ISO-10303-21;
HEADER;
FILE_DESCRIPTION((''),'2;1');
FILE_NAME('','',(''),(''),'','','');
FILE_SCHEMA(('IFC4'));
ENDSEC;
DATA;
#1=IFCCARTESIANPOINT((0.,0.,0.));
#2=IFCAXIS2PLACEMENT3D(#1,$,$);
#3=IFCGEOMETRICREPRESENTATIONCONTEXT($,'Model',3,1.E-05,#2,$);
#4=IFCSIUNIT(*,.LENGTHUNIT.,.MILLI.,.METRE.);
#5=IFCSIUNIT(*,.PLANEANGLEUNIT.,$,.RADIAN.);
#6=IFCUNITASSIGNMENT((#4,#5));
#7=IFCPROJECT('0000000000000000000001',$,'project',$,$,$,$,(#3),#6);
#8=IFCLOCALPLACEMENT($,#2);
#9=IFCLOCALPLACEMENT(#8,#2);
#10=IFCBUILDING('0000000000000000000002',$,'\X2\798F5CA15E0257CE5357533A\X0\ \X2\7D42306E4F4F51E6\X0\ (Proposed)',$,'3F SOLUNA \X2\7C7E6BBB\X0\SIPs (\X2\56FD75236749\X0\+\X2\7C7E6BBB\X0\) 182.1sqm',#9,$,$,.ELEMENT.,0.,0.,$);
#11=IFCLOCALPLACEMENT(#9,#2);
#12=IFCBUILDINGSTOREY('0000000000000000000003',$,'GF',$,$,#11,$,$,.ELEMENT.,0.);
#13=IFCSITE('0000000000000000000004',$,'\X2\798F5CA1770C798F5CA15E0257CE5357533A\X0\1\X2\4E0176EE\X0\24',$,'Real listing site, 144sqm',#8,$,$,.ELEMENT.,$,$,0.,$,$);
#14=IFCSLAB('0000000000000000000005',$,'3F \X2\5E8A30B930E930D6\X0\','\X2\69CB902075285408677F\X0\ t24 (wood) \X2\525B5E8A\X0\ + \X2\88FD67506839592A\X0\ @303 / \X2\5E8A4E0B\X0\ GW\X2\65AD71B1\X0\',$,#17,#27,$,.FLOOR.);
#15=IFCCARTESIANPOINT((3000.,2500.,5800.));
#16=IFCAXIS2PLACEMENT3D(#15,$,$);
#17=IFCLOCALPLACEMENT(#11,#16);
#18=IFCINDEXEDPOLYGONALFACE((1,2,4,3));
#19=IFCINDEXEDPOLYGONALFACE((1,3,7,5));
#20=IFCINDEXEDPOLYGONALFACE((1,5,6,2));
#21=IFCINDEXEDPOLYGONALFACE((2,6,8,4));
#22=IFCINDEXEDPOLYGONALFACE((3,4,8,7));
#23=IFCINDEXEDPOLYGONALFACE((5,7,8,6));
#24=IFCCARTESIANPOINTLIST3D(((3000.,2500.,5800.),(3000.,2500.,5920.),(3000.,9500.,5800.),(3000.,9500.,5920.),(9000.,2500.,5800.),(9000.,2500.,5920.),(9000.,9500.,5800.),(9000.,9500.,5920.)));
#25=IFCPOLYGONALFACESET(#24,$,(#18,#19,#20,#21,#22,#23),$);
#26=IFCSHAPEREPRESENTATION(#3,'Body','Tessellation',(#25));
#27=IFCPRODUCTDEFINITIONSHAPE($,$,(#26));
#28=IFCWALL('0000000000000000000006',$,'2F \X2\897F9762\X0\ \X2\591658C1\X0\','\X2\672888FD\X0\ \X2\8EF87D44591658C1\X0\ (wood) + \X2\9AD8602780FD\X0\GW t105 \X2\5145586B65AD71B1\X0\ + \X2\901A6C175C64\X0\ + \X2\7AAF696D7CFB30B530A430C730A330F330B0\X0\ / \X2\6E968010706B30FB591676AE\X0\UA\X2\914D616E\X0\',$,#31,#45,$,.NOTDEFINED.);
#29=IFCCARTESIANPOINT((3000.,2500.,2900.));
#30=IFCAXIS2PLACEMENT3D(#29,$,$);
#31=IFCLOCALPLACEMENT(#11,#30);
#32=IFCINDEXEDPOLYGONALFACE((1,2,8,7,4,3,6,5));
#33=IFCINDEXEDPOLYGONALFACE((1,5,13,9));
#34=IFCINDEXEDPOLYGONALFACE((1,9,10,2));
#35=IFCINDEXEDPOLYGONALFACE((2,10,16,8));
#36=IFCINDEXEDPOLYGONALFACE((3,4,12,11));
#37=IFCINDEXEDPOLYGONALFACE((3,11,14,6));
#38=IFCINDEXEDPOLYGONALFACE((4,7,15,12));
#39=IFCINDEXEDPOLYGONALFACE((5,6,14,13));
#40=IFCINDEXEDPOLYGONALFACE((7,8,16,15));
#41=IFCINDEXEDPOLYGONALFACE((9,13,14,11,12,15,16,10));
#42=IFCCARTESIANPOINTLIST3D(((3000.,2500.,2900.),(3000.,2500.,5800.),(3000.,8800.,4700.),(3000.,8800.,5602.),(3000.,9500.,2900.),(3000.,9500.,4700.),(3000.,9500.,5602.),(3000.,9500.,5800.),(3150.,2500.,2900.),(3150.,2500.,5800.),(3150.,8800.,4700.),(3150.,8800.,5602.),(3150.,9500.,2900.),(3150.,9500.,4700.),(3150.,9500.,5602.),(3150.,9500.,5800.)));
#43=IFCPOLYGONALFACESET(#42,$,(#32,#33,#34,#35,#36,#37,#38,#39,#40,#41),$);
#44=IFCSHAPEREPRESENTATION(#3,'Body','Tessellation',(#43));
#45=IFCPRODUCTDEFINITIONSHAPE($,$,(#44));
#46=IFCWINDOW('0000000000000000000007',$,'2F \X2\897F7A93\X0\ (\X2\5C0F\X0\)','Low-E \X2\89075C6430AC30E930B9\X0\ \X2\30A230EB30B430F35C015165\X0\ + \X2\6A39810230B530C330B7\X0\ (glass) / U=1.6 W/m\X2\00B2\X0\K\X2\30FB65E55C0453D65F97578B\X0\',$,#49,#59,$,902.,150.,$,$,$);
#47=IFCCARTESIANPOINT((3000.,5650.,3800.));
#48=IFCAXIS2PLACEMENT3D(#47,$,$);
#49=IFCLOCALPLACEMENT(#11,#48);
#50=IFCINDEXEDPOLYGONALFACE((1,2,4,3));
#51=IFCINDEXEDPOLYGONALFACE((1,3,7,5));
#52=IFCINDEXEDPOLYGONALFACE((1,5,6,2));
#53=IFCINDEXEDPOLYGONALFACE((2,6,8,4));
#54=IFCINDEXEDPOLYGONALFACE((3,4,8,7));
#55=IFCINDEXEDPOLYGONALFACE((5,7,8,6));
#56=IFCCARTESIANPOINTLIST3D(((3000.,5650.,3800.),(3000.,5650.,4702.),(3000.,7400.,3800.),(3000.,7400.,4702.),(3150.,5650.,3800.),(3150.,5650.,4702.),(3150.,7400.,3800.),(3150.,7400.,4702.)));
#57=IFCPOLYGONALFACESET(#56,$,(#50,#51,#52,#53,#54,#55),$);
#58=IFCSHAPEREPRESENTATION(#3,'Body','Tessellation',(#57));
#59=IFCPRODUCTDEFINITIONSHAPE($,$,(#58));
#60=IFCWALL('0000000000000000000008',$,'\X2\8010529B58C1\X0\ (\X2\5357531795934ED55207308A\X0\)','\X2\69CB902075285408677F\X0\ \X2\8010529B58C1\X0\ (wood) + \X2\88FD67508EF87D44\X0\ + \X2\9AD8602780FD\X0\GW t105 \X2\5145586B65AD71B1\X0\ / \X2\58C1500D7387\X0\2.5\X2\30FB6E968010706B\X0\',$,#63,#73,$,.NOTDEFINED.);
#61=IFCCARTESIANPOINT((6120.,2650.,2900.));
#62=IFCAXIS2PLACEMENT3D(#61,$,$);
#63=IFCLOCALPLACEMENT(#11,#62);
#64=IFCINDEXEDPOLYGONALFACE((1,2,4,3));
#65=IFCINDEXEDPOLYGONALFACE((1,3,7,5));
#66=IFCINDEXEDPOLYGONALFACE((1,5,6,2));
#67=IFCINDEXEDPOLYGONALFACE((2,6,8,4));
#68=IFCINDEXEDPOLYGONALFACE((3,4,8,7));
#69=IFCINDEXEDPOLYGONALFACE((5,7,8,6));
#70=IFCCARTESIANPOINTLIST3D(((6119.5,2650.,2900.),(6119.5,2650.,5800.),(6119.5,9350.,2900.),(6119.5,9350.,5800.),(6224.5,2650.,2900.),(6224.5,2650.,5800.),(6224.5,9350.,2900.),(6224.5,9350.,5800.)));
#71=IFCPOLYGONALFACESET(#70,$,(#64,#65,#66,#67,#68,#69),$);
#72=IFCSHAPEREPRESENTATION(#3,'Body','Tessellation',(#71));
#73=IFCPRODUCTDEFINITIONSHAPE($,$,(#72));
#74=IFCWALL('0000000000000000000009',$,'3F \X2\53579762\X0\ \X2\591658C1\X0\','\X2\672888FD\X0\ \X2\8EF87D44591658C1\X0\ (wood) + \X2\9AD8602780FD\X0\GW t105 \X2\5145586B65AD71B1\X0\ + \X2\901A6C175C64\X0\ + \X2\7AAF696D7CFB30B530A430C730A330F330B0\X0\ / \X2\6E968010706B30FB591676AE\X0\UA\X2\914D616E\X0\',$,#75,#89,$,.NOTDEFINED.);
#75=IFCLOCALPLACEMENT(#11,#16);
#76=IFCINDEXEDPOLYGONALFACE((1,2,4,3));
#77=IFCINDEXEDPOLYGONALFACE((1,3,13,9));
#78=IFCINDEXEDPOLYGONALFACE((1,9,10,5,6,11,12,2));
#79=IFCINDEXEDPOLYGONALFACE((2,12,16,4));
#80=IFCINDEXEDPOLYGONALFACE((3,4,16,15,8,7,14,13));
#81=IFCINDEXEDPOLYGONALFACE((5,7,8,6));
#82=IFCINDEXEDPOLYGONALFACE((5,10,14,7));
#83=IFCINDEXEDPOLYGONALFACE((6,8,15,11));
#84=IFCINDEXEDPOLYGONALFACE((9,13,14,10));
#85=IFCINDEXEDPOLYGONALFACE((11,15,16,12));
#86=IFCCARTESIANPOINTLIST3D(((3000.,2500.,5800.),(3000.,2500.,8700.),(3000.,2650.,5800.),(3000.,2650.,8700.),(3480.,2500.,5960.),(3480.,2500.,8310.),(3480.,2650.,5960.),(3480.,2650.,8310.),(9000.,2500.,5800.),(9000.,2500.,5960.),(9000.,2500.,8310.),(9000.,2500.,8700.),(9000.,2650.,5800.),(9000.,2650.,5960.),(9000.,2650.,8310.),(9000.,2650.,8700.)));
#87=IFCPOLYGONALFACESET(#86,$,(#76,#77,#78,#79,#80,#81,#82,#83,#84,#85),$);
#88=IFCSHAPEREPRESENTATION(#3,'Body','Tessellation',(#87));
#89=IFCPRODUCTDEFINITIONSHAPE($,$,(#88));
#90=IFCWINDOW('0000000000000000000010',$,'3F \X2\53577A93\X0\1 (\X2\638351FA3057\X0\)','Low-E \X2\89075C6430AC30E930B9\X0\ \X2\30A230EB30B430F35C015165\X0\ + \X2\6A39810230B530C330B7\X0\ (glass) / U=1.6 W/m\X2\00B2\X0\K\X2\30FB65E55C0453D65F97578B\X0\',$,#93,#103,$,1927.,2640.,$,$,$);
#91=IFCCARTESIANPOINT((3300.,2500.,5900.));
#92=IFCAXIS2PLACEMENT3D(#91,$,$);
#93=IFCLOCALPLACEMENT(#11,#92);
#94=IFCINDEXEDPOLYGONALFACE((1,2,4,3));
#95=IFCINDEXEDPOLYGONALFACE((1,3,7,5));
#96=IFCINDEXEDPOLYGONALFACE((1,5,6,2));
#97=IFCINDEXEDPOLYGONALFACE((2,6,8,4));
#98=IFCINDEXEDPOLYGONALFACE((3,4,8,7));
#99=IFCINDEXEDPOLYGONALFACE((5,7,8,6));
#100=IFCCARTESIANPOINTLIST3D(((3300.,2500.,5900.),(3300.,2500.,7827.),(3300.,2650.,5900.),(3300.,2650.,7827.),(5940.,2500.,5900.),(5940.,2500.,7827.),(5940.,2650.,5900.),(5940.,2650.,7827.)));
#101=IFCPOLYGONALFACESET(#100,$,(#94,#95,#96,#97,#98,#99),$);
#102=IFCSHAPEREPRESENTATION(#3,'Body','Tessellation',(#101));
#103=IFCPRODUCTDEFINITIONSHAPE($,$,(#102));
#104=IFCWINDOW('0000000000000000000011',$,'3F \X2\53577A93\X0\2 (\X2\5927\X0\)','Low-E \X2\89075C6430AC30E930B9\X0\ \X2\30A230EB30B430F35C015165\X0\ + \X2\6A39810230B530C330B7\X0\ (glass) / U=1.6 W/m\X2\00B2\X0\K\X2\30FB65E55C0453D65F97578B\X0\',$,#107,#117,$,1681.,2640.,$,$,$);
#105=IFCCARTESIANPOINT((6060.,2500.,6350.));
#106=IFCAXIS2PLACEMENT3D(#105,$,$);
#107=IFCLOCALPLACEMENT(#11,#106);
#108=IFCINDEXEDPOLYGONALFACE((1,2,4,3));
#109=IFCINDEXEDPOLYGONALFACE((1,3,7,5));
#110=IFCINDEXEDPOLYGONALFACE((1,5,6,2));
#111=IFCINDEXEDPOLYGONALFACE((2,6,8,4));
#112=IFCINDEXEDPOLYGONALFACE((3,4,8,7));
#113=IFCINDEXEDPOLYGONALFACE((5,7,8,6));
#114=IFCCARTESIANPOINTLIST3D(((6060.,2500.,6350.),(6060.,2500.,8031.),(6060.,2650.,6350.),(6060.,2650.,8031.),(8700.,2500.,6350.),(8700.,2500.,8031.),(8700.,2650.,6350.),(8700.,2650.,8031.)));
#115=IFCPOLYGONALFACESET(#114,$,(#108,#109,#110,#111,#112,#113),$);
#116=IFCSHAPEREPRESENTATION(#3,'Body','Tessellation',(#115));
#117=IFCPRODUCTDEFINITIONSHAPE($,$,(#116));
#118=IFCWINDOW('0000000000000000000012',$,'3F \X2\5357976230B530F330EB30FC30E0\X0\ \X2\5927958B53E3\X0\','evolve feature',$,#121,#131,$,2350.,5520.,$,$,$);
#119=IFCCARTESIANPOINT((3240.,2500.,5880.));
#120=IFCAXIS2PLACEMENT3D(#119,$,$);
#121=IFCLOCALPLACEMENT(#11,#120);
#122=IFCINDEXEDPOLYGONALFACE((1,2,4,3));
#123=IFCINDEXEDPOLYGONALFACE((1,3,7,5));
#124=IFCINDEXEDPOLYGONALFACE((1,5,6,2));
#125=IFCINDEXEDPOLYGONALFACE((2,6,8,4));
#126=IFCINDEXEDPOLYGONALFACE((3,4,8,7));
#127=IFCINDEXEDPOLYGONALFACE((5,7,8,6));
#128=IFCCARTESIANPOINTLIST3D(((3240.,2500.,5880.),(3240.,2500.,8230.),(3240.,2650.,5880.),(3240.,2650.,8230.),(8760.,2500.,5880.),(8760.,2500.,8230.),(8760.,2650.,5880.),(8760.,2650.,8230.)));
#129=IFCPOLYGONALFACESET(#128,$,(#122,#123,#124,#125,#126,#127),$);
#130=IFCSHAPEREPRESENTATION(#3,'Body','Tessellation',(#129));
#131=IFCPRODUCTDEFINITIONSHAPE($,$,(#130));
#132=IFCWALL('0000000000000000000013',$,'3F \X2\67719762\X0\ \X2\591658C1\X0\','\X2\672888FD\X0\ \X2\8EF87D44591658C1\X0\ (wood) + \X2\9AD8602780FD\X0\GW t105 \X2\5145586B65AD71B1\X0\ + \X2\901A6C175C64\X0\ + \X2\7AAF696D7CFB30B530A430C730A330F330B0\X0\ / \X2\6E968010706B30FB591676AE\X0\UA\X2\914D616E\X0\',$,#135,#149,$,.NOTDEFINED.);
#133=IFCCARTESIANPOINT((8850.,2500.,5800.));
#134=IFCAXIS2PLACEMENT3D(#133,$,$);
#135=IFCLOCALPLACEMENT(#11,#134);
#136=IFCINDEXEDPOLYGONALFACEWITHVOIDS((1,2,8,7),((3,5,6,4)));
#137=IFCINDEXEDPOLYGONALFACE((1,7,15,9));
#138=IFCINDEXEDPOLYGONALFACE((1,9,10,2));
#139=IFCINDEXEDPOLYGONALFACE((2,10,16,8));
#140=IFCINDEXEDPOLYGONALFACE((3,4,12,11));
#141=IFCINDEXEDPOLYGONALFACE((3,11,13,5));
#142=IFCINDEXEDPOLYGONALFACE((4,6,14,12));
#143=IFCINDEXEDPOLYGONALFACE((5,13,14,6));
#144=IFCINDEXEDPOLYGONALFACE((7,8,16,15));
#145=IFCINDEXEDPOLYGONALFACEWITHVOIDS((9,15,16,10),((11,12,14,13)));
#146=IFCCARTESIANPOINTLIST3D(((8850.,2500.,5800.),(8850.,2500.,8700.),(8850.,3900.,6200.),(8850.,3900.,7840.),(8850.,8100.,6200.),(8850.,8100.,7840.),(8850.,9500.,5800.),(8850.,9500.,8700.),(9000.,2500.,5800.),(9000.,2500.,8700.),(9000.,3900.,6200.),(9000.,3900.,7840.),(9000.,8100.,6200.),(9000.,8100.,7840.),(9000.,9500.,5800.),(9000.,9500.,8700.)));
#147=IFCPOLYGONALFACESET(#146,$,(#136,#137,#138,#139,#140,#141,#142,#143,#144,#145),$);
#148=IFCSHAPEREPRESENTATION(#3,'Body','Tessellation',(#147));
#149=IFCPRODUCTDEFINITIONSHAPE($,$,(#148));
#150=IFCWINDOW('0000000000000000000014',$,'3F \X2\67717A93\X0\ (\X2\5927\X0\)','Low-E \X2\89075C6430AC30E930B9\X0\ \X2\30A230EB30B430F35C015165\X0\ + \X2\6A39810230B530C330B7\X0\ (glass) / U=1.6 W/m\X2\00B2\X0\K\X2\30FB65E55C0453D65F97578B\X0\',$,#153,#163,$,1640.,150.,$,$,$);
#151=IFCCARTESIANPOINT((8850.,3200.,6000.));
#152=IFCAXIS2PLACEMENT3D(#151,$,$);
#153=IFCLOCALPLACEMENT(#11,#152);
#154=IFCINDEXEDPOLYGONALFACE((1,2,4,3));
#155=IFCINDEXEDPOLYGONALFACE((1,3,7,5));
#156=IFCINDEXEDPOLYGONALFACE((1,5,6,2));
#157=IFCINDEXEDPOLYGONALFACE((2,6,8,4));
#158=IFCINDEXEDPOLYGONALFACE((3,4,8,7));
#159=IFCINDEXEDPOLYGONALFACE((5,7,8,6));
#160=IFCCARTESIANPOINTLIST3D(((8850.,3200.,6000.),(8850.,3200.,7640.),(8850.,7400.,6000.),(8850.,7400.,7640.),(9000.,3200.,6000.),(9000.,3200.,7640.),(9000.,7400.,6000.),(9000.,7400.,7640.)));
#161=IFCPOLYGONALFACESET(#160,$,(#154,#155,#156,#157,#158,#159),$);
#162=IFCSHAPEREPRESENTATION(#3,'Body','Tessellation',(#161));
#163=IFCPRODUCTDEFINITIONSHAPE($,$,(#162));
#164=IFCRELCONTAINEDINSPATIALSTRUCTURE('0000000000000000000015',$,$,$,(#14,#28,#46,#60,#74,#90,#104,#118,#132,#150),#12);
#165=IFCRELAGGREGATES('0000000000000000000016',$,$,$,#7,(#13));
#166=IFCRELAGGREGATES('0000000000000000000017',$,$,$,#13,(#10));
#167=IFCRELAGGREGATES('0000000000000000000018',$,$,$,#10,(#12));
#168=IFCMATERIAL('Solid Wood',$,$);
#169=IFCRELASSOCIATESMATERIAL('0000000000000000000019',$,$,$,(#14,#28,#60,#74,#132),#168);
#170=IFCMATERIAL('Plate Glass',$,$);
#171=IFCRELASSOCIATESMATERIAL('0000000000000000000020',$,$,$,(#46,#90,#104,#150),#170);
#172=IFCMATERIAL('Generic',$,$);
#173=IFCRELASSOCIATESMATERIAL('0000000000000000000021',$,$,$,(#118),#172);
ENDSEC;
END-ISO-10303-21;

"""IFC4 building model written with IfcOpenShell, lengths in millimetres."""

from ifc_helpers import new_model, si_unit, frame, frame_2d, origin, place, context, project, spatial, rectangle, extrude, material, element, fill, save


model = new_model("IFC4")

# Units and contexts
model_context = context("Model", 3, precision=1e-05, world=origin())
ifc_project = project(units=[si_unit("LENGTHUNIT", "METRE", prefix="MILLI"), si_unit("PLANEANGLEUNIT", "RADIAN")], contexts=[model_context])

# Site, building, storey
site_placement = place(None, origin())
site = spatial("IfcSite", under=ifc_project, at=site_placement, Name="福岡県福岡市城南区1丁目24", ObjectType="Real listing site, 144sqm", CompositionType="ELEMENT", RefElevation=0.0)
building_placement = place(site_placement, origin())
building = spatial("IfcBuilding", under=site, at=building_placement, Name="福岡市城南区 終の住処 (Proposed)", ObjectType="3F SOLUNA 籾殻SIPs (国産杉+籾殻) 182.1sqm", CompositionType="ELEMENT", ElevationOfRefHeight=0.0, ElevationOfTerrain=0.0)
storey_placement = place(building_placement, origin())
storey = spatial("IfcBuildingStorey", under=building, at=storey_placement, Name="GF", CompositionType="ELEMENT", Elevation=0.0)

# Slab
ifc_material_1 = material(Name="Solid Wood")
slab_placement = place(storey_placement, frame((3000.0, 2500.0, 5800.0)))
element("IfcSlab", 1, at=slab_placement, inside=storey, material=ifc_material_1, Name="3F 床スラブ", Description="構造用合板 t24 (wood) 剛床 + 製材根太 @303 / 床下 GW断熱", PredefinedType="FLOOR", context=model_context, shape_type="SweptSolid", body=[
    extrude(rectangle(XDim=6000.0, YDim=7000.0, at=frame_2d((3000.0, 3500.0))), frame((3000.0, 2500.0, 5800.0)), (0.0, 0.0, 1.0), 120.0),
])

# Wall, opening, window
wall_1_placement = place(storey_placement, frame((3000.0, 2500.0, 2900.0)))
wall_1 = element("IfcWall", 2, at=wall_1_placement, inside=storey, material=ifc_material_1, Name="2F 西面 外壁", Description="木製 軸組外壁 (wood) + 高性能GW t105 充填断熱 + 通気層 + 窯業系サイディング / 準耐火・外皮UA配慮", PredefinedType="NOTDEFINED", context=model_context, shape_type="SweptSolid", body=[
    extrude(rectangle(XDim=150.0, YDim=7000.0, at=frame_2d((75.0, 3500.0))), frame((3000.0, 2500.0, 2900.0)), (0.0, 0.0, 1.0), 2900.0),
])
opening_1_placement = place(storey_placement, frame((3000.0, 5650.0, 3800.0)))
opening_1 = element("IfcOpeningElement", 3, at=opening_1_placement, cuts=wall_1, PredefinedType="NOTDEFINED", context=model_context, shape_type="SweptSolid", body=[
    extrude(rectangle(XDim=150.0, YDim=1750.0, at=frame_2d((75.0, 875.0))), frame((3000.0, 5650.0, 3800.0)), (0.0, 0.0, 1.0), 902.0),
])
ifc_material_2 = material(Name="Plate Glass")
window_1_placement = place(storey_placement, frame((3000.0, 5650.0, 3800.0)))
window_1 = element("IfcWindow", 4, at=window_1_placement, inside=storey, material=ifc_material_2, Name="2F 西窓 (小)", Description="Low-E 複層ガラス アルゴン封入 + 樹脂サッシ (glass) / U=1.6 W/m²K・日射取得型", OverallHeight=902.0, OverallWidth=150.0, context=model_context, shape_type="SweptSolid", body=[
    extrude(rectangle(XDim=150.0, YDim=1750.0, at=frame_2d((75.0, 875.0))), frame((3000.0, 5650.0, 3800.0)), (0.0, 0.0, 1.0), 902.0),
])
fill(opening_1, window_1)

# Wall
wall_2_placement = place(storey_placement, frame((6120.0, 2650.0, 2900.0)))
element("IfcWall", 5, at=wall_2_placement, inside=storey, material=ifc_material_1, Name="耐力壁 (南北間仕切り)", Description="構造用合板 耐力壁 (wood) + 製材軸組 + 高性能GW t105 充填断熱 / 壁倍率2.5・準耐火", PredefinedType="NOTDEFINED", context=model_context, shape_type="SweptSolid", body=[
    extrude(rectangle(XDim=105.0, YDim=6700.0, at=frame_2d((52.0, 3350.0))), frame((6120.0, 2650.0, 2900.0)), (0.0, 0.0, 1.0), 2900.0),
])

# Wall, openings, windows
wall_3_placement = place(storey_placement, frame((3000.0, 2500.0, 5800.0)))
wall_3 = element("IfcWall", 6, at=wall_3_placement, inside=storey, material=ifc_material_1, Name="3F 南面 外壁", Description="木製 軸組外壁 (wood) + 高性能GW t105 充填断熱 + 通気層 + 窯業系サイディング / 準耐火・外皮UA配慮", PredefinedType="NOTDEFINED", context=model_context, shape_type="SweptSolid", body=[
    extrude(rectangle(XDim=6000.0, YDim=150.0, at=frame_2d((3000.0, 75.0))), frame((3000.0, 2500.0, 5800.0)), (0.0, 0.0, 1.0), 2900.0),
])
opening_2_placement = place(storey_placement, frame((3300.0, 2500.0, 5900.0)))
opening_2 = element("IfcOpeningElement", 7, at=opening_2_placement, cuts=wall_3, PredefinedType="NOTDEFINED", context=model_context, shape_type="SweptSolid", body=[
    extrude(rectangle(XDim=2640.0, YDim=150.0, at=frame_2d((1320.0, 75.0))), frame((3300.0, 2500.0, 5900.0)), (0.0, 0.0, 1.0), 1927.0),
])
opening_3_placement = place(storey_placement, frame((6060.0, 2500.0, 6350.0)))
opening_3 = element("IfcOpeningElement", 8, at=opening_3_placement, cuts=wall_3, PredefinedType="NOTDEFINED", context=model_context, shape_type="SweptSolid", body=[
    extrude(rectangle(XDim=2640.0, YDim=150.0, at=frame_2d((1320.0, 75.0))), frame((6060.0, 2500.0, 6350.0)), (0.0, 0.0, 1.0), 1681.0),
])
opening_4_placement = place(storey_placement, frame((3240.0, 2500.0, 5880.0)))
opening_4 = element("IfcOpeningElement", 9, at=opening_4_placement, cuts=wall_3, PredefinedType="NOTDEFINED", context=model_context, shape_type="SweptSolid", body=[
    extrude(rectangle(XDim=5520.0, YDim=150.0, at=frame_2d((2760.0, 75.0))), frame((3240.0, 2500.0, 5880.0)), (0.0, 0.0, 1.0), 2350.0),
])
window_2_placement = place(storey_placement, frame((3300.0, 2500.0, 5900.0)))
window_2 = element("IfcWindow", 10, at=window_2_placement, inside=storey, material=ifc_material_2, Name="3F 南窓1 (掃出し)", Description="Low-E 複層ガラス アルゴン封入 + 樹脂サッシ (glass) / U=1.6 W/m²K・日射取得型", OverallHeight=1927.0, OverallWidth=2640.0, context=model_context, shape_type="SweptSolid", body=[
    extrude(rectangle(XDim=2640.0, YDim=150.0, at=frame_2d((1320.0, 75.0))), frame((3300.0, 2500.0, 5900.0)), (0.0, 0.0, 1.0), 1927.0),
])
fill(opening_2, window_2)
window_3_placement = place(storey_placement, frame((6060.0, 2500.0, 6350.0)))
window_3 = element("IfcWindow", 11, at=window_3_placement, inside=storey, material=ifc_material_2, Name="3F 南窓2 (大)", Description="Low-E 複層ガラス アルゴン封入 + 樹脂サッシ (glass) / U=1.6 W/m²K・日射取得型", OverallHeight=1681.0, OverallWidth=2640.0, context=model_context, shape_type="SweptSolid", body=[
    extrude(rectangle(XDim=2640.0, YDim=150.0, at=frame_2d((1320.0, 75.0))), frame((6060.0, 2500.0, 6350.0)), (0.0, 0.0, 1.0), 1681.0),
])
fill(opening_3, window_3)
ifc_material_3 = material(Name="Generic")
window_4_placement = place(storey_placement, frame((3240.0, 2500.0, 5880.0)))
window_4 = element("IfcWindow", 12, at=window_4_placement, inside=storey, material=ifc_material_3, Name="3F 南面サンルーム 大開口", Description="evolve feature", OverallHeight=2350.0, OverallWidth=5520.0, context=model_context, shape_type="SweptSolid", body=[
    extrude(rectangle(XDim=5520.0, YDim=150.0, at=frame_2d((2760.0, 75.0))), frame((3240.0, 2500.0, 5880.0)), (0.0, 0.0, 1.0), 2350.0),
])
fill(opening_4, window_4)

# Wall, opening, window
wall_4_placement = place(storey_placement, frame((8850.0, 2500.0, 5800.0)))
wall_4 = element("IfcWall", 13, at=wall_4_placement, inside=storey, material=ifc_material_1, Name="3F 東面 外壁", Description="木製 軸組外壁 (wood) + 高性能GW t105 充填断熱 + 通気層 + 窯業系サイディング / 準耐火・外皮UA配慮", PredefinedType="NOTDEFINED", context=model_context, shape_type="SweptSolid", body=[
    extrude(rectangle(XDim=150.0, YDim=7000.0, at=frame_2d((75.0, 3500.0))), frame((8850.0, 2500.0, 5800.0)), (0.0, 0.0, 1.0), 2900.0),
])
opening_5_placement = place(storey_placement, frame((8850.0, 3200.0, 6000.0)))
opening_5 = element("IfcOpeningElement", 14, at=opening_5_placement, cuts=wall_4, PredefinedType="NOTDEFINED", context=model_context, shape_type="SweptSolid", body=[
    extrude(rectangle(XDim=150.0, YDim=4200.0, at=frame_2d((75.0, 2100.0))), frame((8850.0, 3200.0, 6000.0)), (0.0, 0.0, 1.0), 1640.0),
])
window_5_placement = place(storey_placement, frame((8850.0, 3200.0, 6000.0)))
window_5 = element("IfcWindow", 15, at=window_5_placement, inside=storey, material=ifc_material_2, Name="3F 東窓 (大)", Description="Low-E 複層ガラス アルゴン封入 + 樹脂サッシ (glass) / U=1.6 W/m²K・日射取得型", OverallHeight=1640.0, OverallWidth=150.0, context=model_context, shape_type="SweptSolid", body=[
    extrude(rectangle(XDim=150.0, YDim=4200.0, at=frame_2d((75.0, 2100.0))), frame((8850.0, 3200.0, 6000.0)), (0.0, 0.0, 1.0), 1640.0),
])
fill(opening_5, window_5)

save(model, "model.ifc")
